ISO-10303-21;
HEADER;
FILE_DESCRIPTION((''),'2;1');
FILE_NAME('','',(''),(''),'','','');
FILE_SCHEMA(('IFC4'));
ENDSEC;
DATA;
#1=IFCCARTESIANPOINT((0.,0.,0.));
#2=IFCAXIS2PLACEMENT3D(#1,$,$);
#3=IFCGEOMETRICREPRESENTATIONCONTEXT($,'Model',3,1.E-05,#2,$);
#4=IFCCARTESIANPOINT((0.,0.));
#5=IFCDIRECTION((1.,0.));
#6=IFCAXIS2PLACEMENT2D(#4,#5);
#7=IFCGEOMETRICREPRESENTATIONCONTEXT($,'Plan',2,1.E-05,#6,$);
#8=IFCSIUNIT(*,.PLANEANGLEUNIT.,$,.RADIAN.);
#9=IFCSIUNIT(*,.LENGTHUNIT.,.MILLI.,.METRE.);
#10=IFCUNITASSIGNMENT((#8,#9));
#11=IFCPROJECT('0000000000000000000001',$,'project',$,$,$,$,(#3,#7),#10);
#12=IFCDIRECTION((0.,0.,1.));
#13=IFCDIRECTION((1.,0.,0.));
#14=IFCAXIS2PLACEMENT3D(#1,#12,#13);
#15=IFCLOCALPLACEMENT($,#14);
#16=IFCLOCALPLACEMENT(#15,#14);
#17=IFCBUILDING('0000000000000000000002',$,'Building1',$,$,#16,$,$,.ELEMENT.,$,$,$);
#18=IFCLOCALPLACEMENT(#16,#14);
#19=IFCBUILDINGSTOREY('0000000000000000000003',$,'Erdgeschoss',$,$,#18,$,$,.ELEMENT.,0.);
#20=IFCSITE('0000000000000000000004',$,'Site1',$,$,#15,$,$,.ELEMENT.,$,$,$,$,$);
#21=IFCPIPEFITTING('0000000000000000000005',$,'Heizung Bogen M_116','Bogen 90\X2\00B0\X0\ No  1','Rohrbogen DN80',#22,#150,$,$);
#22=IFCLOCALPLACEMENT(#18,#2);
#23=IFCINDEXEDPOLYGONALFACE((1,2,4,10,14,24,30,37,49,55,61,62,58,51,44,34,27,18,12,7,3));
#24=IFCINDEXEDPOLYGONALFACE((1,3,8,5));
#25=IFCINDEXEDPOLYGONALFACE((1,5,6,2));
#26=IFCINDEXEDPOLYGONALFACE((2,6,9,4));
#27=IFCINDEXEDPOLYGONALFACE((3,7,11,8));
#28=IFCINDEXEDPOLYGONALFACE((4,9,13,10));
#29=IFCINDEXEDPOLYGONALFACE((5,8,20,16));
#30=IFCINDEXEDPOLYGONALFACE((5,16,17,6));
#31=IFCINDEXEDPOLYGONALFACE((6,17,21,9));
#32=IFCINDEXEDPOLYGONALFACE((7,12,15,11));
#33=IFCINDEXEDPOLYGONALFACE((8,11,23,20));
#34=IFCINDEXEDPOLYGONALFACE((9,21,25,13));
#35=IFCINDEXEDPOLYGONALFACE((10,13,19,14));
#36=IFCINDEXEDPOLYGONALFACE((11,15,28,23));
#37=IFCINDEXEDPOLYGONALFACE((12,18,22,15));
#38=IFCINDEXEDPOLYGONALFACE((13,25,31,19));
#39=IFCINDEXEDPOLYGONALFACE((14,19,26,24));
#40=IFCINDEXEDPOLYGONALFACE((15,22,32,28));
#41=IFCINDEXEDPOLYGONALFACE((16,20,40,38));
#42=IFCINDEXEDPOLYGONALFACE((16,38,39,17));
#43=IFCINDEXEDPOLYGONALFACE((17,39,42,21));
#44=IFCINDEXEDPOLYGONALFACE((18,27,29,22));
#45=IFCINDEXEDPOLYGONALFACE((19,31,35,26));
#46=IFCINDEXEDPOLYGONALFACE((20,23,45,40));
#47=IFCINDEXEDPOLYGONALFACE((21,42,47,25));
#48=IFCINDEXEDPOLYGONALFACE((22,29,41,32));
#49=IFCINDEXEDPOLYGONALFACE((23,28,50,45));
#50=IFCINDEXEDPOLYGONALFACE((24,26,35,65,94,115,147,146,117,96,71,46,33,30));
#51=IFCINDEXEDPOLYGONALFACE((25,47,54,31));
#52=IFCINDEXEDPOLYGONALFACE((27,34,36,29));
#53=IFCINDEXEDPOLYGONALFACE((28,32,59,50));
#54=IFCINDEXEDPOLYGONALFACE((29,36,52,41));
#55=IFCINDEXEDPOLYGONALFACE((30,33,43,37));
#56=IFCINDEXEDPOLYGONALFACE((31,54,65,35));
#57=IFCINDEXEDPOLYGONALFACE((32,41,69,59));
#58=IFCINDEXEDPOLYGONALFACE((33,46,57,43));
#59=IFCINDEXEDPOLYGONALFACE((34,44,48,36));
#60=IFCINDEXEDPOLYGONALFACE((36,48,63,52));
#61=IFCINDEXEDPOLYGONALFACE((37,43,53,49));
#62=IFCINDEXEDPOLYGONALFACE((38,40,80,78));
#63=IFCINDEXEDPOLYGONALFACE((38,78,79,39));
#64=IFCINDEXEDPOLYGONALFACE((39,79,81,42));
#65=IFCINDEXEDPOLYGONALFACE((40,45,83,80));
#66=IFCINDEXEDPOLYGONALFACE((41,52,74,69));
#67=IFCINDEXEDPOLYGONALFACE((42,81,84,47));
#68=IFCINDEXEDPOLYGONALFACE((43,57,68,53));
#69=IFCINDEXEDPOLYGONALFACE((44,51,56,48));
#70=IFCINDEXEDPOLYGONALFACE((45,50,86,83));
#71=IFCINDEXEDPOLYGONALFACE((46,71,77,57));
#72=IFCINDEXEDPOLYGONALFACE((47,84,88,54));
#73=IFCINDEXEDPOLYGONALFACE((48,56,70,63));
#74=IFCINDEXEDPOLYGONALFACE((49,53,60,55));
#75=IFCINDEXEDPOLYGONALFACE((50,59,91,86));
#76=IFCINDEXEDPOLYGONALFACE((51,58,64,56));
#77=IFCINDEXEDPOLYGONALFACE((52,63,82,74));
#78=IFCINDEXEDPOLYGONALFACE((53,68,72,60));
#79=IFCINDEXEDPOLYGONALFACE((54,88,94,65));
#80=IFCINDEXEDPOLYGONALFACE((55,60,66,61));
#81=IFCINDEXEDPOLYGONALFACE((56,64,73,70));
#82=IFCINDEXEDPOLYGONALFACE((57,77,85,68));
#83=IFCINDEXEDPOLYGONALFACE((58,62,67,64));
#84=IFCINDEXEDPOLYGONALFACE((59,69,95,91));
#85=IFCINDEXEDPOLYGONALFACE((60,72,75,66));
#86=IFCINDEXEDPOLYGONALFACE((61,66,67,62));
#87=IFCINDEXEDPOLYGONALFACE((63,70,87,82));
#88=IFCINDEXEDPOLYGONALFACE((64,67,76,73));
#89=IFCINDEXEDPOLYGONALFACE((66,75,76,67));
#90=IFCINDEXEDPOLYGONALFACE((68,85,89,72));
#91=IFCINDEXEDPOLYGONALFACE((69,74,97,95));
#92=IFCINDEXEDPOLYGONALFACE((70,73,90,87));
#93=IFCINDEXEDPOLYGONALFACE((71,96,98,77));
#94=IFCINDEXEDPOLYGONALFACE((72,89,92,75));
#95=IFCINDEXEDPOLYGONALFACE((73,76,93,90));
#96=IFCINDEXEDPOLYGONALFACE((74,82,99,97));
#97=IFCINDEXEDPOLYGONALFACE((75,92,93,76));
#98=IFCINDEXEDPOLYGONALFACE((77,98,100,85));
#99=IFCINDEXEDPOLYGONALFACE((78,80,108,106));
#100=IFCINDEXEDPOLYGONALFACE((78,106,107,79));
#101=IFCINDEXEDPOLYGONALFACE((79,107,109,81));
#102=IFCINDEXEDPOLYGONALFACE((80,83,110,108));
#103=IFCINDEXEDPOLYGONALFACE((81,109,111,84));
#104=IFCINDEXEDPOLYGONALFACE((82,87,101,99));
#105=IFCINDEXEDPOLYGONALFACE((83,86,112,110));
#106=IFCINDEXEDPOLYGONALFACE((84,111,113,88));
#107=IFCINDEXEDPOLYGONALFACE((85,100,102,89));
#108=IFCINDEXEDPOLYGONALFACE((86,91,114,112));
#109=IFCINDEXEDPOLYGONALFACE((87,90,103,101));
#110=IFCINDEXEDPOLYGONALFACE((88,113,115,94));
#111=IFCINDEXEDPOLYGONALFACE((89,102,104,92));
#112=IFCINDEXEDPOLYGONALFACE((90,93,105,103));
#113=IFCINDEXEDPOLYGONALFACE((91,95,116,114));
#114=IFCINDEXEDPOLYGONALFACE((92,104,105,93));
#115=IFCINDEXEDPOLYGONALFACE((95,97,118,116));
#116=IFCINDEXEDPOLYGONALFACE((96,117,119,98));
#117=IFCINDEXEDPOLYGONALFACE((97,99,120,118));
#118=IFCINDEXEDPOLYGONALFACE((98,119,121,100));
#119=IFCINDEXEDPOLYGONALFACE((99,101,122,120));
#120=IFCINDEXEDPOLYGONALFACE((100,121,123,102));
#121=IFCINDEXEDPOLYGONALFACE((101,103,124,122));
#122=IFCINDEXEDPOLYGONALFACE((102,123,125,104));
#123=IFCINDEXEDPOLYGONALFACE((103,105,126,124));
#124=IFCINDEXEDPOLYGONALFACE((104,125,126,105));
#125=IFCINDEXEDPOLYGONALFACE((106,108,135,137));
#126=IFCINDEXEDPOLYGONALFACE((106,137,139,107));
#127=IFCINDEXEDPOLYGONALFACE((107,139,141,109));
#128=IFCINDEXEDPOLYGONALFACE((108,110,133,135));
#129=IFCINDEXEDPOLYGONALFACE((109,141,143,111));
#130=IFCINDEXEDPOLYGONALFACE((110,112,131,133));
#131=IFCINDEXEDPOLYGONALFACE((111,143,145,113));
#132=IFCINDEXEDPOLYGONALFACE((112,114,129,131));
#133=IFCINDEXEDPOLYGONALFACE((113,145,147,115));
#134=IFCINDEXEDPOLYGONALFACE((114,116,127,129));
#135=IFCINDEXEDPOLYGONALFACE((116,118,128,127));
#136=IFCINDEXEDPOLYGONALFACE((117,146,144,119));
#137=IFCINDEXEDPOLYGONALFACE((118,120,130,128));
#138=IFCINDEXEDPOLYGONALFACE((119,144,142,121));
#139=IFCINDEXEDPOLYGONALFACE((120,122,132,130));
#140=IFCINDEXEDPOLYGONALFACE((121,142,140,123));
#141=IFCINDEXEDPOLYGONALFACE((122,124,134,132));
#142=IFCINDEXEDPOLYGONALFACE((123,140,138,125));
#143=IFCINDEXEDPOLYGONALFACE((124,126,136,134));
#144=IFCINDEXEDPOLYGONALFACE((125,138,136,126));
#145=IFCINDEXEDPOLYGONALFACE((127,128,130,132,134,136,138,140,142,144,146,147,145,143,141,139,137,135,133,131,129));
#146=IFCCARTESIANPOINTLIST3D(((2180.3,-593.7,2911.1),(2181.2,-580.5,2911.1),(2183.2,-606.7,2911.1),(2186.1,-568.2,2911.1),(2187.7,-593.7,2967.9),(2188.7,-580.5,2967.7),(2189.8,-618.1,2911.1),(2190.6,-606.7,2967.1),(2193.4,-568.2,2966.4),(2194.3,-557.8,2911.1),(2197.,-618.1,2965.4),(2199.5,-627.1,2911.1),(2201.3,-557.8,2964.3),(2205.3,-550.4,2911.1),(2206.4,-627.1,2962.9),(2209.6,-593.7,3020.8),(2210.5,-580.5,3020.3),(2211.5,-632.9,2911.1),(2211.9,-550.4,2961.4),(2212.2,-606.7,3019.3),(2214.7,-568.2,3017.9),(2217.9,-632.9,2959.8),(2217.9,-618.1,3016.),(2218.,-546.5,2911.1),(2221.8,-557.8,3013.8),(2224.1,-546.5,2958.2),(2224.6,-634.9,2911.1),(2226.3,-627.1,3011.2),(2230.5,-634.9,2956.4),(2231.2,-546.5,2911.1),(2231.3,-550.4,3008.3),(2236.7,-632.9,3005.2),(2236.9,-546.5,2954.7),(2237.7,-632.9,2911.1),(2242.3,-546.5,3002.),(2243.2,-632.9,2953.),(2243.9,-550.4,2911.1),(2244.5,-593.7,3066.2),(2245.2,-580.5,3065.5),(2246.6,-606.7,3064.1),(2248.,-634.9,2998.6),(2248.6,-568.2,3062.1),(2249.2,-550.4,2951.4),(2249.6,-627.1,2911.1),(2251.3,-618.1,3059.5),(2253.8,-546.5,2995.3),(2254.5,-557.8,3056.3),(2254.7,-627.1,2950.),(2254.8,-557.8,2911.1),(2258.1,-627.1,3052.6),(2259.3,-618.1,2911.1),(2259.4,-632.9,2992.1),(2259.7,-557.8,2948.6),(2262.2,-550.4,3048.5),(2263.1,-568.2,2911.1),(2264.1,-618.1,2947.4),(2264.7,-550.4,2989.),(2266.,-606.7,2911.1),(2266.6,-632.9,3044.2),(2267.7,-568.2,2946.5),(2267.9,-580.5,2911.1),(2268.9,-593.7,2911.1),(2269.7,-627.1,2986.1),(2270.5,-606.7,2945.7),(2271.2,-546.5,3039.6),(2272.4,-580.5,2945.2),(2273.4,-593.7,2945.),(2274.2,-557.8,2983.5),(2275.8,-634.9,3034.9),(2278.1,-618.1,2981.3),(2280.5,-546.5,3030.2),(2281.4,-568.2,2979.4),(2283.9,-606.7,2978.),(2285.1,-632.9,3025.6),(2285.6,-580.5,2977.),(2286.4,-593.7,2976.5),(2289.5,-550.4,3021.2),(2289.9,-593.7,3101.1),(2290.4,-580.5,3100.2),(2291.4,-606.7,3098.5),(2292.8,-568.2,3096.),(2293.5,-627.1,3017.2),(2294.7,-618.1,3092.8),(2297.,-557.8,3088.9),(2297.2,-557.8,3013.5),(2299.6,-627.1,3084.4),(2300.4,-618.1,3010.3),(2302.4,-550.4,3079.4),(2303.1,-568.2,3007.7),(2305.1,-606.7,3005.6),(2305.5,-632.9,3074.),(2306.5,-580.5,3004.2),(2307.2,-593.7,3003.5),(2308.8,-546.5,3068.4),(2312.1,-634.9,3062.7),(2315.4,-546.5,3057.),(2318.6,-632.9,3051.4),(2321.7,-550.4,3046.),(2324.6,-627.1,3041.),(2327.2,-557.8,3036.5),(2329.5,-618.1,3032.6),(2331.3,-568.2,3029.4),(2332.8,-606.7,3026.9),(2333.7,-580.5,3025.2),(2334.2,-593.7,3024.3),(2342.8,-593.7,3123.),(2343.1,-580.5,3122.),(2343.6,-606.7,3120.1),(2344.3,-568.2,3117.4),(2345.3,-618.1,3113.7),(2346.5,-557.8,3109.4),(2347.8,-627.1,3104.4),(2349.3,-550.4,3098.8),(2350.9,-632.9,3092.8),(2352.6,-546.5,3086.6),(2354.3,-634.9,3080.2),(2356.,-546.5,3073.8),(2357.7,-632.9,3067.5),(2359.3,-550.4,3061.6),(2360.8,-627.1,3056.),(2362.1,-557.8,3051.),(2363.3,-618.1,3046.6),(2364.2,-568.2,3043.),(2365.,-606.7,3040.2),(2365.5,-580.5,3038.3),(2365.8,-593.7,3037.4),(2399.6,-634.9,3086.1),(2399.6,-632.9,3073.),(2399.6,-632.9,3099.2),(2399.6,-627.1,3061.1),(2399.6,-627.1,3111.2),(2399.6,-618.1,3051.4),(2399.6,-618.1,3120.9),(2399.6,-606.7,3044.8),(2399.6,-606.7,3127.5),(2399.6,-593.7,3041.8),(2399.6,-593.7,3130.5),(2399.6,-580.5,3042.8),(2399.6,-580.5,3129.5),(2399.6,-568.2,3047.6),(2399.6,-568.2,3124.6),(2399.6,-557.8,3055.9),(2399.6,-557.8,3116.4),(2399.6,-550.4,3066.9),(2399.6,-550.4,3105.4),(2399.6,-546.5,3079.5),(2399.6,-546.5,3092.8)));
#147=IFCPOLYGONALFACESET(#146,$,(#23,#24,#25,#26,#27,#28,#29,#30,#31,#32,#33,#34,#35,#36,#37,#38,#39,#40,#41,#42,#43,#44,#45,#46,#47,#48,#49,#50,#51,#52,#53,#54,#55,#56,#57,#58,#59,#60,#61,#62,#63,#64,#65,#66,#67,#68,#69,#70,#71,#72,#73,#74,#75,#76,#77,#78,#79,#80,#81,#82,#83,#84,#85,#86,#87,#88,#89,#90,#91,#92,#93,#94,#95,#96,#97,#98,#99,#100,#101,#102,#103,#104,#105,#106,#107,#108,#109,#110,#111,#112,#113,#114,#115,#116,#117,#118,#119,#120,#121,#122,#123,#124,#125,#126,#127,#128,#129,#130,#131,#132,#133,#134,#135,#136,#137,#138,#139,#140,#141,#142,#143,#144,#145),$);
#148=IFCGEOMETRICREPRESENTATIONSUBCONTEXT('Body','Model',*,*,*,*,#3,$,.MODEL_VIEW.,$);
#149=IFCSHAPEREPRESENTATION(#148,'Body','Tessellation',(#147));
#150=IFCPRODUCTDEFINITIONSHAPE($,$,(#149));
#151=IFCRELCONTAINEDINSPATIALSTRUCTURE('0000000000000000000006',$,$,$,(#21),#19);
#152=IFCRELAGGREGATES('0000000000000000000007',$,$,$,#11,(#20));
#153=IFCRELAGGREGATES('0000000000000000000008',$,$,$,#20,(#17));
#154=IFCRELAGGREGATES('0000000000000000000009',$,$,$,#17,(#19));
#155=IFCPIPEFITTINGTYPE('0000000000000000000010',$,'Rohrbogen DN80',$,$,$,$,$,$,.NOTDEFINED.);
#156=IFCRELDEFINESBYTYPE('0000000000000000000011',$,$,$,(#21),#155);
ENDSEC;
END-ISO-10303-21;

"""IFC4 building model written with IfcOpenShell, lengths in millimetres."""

from ifc_helpers import new_model, entity, si_unit, frame, origin, origin_with_axes, origin_2d_with_axis, place, context, subcontext, project, spatial, source, transform, mapped, type_object, element, save


model = new_model("IFC4")

# Units and contexts
model_context = context("Model", 3, precision=1e-05, world=origin())
plan_context = context("Plan", 2, precision=1e-05, world=origin_2d_with_axis())
body_context = subcontext(model_context, "Body", "Model", "MODEL_VIEW")
ifc_project = project(units=[si_unit("PLANEANGLEUNIT", "RADIAN"), si_unit("LENGTHUNIT", "METRE", prefix="MILLI")], contexts=[model_context, plan_context])

# Site, building, storey
site_placement = place(None, origin_with_axes())
site = spatial("IfcSite", under=ifc_project, at=site_placement, Name="Site1", CompositionType="ELEMENT")
building_placement = place(site_placement, origin_with_axes())
building = spatial("IfcBuilding", under=site, at=building_placement, Name="Building1", CompositionType="ELEMENT")
storey_placement = place(building_placement, origin_with_axes())
storey = spatial("IfcBuildingStorey", under=building, at=storey_placement, Name="Erdgeschoss", CompositionType="ELEMENT", Elevation=0.0)

# Pipe fitting
pipe_fitting_type_1 = type_object("IfcPipeFittingType", Name="Rohrbogen DN80", PredefinedType="NOTDEFINED")
ifc_direction_1 = entity("IfcDirection", [-1.0, 0.0, 0.0])
shared_shape_1 = source(origin_with_axes(), body_context, "Body", "SolidModel", [
    entity("IfcRevolvedAreaSolid", entity("IfcCircleProfileDef", "AREA", None, entity("IfcAxis2Placement2D", entity("IfcCartesianPoint", [0.0, 0.0]), entity("IfcDirection", [1.0, 0.0])), 44.5), entity("IfcAxis2Placement3D", entity("IfcCartesianPoint", [109.7, -65.3, 0.0]), ifc_direction_1, entity("IfcDirection", [0.0, 0.0, 1.0])), entity("IfcAxis1Placement", entity("IfcCartesianPoint", [0.0, 175.0, 0.0]), ifc_direction_1), 1.570796),
])
pipe_fitting_1_placement = place(storey_placement, frame((2289.9, -590.4, 3020.9), z_axis=(0.0, 0.0, 1.0), x_axis=(1.0, 0.0, 0.0)))
element("IfcPipeFitting", 1, at=pipe_fitting_1_placement, inside=storey, type_object=pipe_fitting_type_1, Name="Heizung Bogen M_116", Description="Bogen 90° No  1", ObjectType="Rohrbogen DN80", context=body_context, shape_type="MappedRepresentation", body=[
    mapped(shared_shape_1, transform((0.0, 0.0, 0.0), x_axis=(0.0, 0.0, -1.0), y_axis=(1.0, 0.0, 0.0), z_axis=(0.0, -1.0, 0.0), scale=1.0)),
])

save(model, "model.ifc")
